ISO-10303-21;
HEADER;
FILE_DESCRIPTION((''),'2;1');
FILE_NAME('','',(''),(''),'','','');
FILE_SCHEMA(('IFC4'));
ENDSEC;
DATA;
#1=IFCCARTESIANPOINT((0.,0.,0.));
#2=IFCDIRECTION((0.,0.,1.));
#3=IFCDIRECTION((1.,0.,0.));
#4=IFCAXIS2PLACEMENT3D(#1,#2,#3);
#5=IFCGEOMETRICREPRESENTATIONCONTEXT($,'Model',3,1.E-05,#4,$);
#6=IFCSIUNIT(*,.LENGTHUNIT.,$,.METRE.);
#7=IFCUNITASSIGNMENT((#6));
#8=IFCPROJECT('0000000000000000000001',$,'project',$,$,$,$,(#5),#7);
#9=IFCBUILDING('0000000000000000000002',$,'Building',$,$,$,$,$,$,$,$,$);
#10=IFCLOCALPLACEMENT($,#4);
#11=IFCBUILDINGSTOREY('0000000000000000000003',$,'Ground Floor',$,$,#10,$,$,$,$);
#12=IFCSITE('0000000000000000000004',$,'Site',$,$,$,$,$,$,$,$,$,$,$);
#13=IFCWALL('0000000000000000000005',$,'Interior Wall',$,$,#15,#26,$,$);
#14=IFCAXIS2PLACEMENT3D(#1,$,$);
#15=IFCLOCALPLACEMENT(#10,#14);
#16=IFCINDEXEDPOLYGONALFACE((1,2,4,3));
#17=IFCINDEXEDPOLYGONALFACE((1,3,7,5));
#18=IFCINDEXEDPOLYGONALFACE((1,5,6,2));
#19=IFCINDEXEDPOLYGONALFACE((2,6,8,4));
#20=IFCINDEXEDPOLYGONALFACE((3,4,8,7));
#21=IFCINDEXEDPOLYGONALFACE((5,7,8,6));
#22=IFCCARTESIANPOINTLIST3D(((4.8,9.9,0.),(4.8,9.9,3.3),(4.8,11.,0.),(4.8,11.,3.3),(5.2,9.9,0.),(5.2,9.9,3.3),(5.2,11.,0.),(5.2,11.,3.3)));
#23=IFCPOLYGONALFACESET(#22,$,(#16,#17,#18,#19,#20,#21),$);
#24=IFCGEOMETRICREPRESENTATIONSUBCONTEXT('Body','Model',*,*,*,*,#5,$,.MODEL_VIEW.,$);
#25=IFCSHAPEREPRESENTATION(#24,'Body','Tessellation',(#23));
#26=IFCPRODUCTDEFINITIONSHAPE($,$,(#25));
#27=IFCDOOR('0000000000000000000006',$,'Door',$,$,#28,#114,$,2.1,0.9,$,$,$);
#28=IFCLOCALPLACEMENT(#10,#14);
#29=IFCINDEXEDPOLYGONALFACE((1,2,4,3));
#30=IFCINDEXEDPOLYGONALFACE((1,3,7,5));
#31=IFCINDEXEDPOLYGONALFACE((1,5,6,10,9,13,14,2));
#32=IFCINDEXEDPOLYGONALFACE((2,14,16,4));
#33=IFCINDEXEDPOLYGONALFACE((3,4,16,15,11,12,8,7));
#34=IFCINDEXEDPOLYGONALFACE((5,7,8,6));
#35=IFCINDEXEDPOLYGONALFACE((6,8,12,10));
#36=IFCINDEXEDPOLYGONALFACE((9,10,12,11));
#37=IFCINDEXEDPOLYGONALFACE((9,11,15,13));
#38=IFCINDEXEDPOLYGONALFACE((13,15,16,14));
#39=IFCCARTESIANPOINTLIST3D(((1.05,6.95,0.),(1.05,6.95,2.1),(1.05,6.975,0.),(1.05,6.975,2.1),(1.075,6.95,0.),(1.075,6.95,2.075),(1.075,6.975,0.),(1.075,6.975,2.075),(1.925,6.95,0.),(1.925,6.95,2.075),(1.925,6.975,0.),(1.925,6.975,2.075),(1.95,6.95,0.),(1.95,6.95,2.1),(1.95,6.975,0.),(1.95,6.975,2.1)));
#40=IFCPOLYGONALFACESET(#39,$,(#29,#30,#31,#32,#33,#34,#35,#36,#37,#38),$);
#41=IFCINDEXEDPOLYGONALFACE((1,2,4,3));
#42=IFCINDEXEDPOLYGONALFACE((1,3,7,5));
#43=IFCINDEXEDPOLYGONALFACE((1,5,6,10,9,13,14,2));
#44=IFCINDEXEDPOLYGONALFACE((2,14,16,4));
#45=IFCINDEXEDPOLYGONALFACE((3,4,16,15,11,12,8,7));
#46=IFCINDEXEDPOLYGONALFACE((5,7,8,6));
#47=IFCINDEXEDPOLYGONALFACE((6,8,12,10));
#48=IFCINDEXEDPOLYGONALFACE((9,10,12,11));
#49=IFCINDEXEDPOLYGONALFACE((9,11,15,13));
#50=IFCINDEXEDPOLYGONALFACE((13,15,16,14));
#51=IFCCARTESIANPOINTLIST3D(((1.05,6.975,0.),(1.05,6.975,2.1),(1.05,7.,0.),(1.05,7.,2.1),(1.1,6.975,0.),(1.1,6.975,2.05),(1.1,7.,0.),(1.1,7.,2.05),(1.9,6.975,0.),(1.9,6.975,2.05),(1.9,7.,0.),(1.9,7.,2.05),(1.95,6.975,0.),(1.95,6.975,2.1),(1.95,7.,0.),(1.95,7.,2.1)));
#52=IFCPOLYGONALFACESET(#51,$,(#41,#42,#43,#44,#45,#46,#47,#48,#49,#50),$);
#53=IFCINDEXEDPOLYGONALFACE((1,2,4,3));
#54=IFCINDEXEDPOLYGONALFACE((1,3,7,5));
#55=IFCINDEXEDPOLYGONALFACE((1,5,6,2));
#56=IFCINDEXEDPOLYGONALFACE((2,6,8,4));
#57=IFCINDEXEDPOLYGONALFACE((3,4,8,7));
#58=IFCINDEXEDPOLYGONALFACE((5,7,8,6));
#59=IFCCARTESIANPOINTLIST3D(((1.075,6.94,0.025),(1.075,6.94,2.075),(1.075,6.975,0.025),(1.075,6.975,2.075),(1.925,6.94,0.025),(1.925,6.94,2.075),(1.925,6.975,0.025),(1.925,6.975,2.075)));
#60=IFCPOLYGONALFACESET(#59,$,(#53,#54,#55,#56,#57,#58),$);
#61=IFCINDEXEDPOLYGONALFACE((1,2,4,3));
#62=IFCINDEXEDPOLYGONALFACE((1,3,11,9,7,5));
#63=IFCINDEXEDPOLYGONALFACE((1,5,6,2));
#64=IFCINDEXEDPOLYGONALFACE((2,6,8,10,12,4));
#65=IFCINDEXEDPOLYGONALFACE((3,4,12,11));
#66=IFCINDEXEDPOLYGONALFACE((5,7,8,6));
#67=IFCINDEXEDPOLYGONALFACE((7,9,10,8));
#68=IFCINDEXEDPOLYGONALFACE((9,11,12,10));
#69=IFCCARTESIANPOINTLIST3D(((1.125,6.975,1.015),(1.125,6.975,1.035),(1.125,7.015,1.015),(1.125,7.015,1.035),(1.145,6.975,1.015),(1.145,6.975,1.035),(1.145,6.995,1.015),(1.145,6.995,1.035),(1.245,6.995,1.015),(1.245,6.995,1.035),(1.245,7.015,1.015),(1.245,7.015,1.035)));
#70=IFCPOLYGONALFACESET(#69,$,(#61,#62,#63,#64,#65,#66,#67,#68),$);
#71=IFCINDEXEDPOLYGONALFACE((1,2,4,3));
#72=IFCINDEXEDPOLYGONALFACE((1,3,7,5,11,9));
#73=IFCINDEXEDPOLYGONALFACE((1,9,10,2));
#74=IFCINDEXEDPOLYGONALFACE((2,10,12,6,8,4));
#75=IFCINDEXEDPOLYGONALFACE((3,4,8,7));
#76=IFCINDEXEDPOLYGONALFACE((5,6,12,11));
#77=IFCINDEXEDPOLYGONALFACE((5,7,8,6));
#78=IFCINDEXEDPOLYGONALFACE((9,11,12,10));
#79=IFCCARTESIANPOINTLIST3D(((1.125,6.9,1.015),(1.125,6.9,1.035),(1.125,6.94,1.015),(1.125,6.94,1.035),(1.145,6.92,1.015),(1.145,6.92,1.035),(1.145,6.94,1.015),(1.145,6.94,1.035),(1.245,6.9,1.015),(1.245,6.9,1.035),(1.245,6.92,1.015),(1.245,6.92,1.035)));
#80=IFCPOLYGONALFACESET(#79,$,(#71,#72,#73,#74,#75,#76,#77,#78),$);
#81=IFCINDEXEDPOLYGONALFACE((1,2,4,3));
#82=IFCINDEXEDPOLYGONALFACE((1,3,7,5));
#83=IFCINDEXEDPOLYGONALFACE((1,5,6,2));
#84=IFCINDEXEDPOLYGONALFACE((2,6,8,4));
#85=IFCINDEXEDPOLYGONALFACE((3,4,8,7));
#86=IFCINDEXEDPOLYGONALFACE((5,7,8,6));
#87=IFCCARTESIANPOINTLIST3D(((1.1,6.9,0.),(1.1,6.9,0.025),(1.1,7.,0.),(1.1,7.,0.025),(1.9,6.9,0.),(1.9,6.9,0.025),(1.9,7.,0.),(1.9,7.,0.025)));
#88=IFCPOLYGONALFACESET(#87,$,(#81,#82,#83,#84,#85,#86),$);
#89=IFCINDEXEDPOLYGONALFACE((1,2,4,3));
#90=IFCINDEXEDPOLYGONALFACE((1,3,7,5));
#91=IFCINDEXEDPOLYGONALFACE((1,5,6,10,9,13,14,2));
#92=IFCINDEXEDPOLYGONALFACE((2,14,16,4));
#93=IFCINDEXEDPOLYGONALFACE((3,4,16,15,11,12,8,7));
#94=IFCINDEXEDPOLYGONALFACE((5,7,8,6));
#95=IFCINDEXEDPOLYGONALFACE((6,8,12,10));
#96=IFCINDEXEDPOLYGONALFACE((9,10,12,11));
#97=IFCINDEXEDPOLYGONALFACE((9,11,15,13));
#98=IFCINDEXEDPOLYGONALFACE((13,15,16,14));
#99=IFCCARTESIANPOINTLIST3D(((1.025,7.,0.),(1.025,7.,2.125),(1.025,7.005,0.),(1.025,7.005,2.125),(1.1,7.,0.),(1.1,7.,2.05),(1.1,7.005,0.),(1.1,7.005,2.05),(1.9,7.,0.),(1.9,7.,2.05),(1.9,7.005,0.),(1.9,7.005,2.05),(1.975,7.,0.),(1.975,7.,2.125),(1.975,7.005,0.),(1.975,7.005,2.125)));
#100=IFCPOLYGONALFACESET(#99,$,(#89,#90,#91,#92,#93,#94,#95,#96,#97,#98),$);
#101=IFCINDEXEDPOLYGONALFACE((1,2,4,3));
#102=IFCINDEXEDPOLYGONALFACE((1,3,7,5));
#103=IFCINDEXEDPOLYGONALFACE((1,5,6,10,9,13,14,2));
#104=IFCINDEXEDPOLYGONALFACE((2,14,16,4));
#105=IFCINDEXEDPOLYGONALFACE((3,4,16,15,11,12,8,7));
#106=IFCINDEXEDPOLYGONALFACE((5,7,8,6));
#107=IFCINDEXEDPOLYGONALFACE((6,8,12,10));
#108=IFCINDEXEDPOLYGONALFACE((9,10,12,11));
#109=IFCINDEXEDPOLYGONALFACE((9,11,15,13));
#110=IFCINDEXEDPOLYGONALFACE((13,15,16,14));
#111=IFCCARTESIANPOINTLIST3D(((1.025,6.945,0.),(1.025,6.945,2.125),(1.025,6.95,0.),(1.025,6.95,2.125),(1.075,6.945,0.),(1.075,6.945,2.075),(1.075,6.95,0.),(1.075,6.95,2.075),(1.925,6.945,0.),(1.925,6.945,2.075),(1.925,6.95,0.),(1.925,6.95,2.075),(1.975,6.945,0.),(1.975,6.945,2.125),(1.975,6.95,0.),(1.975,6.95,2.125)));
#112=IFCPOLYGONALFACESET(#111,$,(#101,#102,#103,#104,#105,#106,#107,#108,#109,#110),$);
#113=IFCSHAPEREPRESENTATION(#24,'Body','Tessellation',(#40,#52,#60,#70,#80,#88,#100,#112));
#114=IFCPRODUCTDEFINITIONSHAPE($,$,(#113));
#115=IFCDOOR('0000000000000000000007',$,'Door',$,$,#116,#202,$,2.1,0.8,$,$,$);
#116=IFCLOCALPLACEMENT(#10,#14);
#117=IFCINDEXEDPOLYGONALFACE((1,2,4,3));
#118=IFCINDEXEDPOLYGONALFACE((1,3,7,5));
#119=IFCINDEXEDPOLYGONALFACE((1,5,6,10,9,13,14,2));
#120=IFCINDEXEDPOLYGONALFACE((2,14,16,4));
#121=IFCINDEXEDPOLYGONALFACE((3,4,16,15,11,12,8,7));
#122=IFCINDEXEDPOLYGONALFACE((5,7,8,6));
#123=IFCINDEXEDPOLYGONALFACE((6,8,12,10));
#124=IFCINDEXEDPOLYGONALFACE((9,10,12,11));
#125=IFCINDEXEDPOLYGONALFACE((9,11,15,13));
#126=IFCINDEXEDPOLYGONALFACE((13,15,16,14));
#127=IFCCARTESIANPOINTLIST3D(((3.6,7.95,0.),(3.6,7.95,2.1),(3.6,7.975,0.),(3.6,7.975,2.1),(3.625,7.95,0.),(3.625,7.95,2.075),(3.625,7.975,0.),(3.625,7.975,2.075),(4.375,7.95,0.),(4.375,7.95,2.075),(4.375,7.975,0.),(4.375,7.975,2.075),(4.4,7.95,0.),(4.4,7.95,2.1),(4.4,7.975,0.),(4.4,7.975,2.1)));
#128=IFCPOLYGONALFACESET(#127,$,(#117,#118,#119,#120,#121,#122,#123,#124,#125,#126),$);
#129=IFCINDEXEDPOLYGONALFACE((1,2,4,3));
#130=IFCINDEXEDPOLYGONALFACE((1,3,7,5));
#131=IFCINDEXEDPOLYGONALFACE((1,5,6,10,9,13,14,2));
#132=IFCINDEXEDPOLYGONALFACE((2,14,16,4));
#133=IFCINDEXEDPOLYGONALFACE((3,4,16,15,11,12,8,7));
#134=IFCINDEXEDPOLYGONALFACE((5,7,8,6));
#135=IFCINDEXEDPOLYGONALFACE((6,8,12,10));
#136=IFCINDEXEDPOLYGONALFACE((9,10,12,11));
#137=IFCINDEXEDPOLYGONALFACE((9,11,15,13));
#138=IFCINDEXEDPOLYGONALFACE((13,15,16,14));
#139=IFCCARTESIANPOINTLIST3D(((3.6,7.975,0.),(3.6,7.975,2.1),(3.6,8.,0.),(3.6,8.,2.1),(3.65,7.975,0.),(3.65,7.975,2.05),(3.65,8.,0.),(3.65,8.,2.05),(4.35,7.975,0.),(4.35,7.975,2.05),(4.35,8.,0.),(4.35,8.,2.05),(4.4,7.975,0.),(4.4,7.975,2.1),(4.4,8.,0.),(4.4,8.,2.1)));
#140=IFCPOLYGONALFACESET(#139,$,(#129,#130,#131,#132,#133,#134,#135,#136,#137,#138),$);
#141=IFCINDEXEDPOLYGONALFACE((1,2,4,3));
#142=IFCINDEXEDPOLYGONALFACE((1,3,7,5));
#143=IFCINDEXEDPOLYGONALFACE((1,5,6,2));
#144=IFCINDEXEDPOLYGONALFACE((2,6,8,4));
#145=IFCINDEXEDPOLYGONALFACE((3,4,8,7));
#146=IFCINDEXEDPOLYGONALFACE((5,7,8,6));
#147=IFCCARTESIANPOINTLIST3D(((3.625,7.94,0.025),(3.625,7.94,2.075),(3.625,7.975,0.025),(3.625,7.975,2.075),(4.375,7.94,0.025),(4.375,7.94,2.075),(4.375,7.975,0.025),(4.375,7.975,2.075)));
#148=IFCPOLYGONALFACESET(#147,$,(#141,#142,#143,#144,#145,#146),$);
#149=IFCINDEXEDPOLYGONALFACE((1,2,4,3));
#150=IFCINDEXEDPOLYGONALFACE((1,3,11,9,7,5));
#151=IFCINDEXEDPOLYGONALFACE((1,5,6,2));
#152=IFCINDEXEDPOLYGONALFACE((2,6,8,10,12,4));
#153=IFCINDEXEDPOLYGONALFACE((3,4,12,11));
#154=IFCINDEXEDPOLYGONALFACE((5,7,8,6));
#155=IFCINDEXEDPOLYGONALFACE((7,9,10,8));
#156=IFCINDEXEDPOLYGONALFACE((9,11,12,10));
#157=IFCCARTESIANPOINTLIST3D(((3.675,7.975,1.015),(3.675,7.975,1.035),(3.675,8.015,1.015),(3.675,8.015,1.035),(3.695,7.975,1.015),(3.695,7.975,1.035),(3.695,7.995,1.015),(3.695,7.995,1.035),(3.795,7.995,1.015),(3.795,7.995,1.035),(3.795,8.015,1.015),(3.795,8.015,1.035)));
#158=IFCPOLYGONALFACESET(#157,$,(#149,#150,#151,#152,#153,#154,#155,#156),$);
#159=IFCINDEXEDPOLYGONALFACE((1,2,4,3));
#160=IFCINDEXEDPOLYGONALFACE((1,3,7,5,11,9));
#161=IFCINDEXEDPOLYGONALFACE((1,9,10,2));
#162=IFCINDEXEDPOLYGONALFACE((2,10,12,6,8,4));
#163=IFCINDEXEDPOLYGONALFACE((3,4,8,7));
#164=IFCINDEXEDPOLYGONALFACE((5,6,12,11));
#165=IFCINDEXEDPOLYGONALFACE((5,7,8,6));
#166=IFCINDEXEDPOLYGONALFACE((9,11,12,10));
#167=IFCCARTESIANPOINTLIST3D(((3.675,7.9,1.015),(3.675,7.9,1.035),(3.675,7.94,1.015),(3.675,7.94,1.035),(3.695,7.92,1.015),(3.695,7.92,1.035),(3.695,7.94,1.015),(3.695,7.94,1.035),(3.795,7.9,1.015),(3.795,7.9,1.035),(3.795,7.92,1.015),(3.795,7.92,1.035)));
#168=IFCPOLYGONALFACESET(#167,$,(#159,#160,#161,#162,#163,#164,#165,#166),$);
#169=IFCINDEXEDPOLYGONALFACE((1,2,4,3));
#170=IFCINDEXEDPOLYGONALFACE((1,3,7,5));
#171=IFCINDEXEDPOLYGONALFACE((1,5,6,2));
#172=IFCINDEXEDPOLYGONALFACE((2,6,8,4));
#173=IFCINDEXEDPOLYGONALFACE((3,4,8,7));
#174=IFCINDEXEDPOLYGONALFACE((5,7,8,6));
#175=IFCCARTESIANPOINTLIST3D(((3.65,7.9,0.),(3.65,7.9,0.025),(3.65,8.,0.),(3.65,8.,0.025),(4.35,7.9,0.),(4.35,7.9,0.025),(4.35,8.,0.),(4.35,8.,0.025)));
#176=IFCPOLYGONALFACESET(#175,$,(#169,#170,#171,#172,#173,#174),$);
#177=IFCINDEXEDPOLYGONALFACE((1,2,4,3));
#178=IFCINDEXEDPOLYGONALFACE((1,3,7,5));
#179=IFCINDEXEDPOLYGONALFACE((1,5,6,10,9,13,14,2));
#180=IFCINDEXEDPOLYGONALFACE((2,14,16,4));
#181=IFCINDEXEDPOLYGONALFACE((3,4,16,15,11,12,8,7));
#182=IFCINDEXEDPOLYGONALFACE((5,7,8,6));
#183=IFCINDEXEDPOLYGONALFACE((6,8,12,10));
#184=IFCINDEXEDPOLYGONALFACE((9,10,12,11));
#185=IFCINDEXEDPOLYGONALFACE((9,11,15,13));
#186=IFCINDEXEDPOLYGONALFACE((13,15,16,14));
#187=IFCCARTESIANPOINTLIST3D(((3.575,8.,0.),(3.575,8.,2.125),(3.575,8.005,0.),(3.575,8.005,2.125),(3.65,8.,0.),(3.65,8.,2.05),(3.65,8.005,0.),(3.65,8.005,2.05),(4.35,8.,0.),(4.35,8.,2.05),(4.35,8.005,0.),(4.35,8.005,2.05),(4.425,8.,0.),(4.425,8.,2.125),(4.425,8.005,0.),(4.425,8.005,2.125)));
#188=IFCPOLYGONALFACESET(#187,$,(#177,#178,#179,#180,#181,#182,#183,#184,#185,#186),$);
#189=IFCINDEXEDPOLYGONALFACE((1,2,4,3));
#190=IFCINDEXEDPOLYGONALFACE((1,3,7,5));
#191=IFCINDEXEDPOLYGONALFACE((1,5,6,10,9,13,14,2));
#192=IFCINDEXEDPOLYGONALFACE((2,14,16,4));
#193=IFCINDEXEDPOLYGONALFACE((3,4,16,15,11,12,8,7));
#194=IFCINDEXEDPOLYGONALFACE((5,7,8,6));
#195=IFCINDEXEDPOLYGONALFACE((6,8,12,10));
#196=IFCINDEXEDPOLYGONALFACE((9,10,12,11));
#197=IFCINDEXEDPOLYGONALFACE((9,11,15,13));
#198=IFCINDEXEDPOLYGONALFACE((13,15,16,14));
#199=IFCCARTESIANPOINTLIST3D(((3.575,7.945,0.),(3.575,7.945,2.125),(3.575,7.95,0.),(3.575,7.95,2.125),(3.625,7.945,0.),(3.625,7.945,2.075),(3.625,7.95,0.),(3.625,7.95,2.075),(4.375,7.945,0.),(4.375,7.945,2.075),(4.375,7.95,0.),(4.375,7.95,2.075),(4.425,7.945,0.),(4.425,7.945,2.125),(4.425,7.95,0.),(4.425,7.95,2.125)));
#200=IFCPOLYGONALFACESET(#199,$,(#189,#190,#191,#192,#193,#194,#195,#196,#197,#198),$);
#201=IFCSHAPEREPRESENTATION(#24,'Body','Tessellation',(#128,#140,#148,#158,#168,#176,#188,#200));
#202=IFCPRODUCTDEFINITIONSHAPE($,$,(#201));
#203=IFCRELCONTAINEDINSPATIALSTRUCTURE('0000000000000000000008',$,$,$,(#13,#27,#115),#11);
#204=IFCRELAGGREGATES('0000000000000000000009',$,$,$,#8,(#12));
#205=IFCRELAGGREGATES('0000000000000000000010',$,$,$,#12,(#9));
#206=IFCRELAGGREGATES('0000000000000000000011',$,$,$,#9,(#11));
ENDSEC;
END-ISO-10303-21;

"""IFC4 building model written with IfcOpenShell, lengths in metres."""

from ifc_helpers import new_model, si_unit, frame, origin_with_axes, place, context, subcontext, project, spatial, line, indexed_curve, outline, extrude, element, save


model = new_model("IFC4")

# Units and contexts
model_context = context("Model", 3, precision=1e-05, world=origin_with_axes())
body_context = subcontext(model_context, "Body", "Model", "MODEL_VIEW")
ifc_project = project(units=[si_unit("LENGTHUNIT", "METRE")], contexts=[model_context])

# Site, building, storey
site = spatial("IfcSite", under=ifc_project, Name="Site")
building = spatial("IfcBuilding", under=site, Name="Building")
storey_placement = place(None, origin_with_axes())
storey = spatial("IfcBuildingStorey", under=building, at=storey_placement, Name="Ground Floor")

# Wall
for number, where, z_axis, x_axis, name in (
    (1, (5.0, 9.9, 0.0), (0.0, 0.0, 1.0), (0.0, 1.0, 0.0), "Interior Wall"),
):
    element("IfcWall", number, at=place(storey_placement, frame(where, z_axis=z_axis, x_axis=x_axis)), inside=storey, Name=name, context=body_context, shape_type="SweptSolid", body=[
        extrude(outline(indexed_curve([(0.0, 0.0), (0.0, 0.4), (1.1, 0.4), (1.1, 0.0), (0.0, 0.0)], self_intersect=False)), frame((0.0, -0.2, 0.0), z_axis=(0.0, 0.0, 1.0), x_axis=(1.0, 0.0, 0.0)), (0.0, 0.0, 1.0), 3.3),
    ])

# Doors
door_1_placement = place(storey_placement, frame((1.95, 7.0, 0.0), z_axis=(0.0, 0.0, 1.0), x_axis=(-1.0, 0.0, 0.0)))
element("IfcDoor", 2, at=door_1_placement, inside=storey, Name="Door", OverallHeight=2.1, OverallWidth=0.9, context=body_context, shape_type="SweptSolid", body=[
    extrude(outline(indexed_curve([(0.0, 0.0), (0.0, 2.1), (0.9, 2.1), (0.9, 0.0), (0.875, 0.0), (0.875, 2.075), (0.025, 2.075), (0.025, 0.0)], segments=[line(1, 2, 3, 4, 5, 6, 7, 8, 1)])), frame((0.0, 0.025, 0.0), z_axis=(0.0, -1.0, 0.0), x_axis=(1.0, 0.0, 0.0)), (0.0, 0.0, -1.0), 0.025),
    extrude(outline(indexed_curve([(0.0, 0.0), (0.0, 2.1), (0.9, 2.1), (0.9, 0.0), (0.85, 0.0), (0.85, 2.05), (0.05, 2.05), (0.05, 0.0)], segments=[line(1, 2, 3, 4, 5, 6, 7, 8, 1)])), frame((0.0, 0.0, 0.0), z_axis=(0.0, -1.0, 0.0), x_axis=(1.0, 0.0, 0.0)), (0.0, 0.0, -1.0), 0.025),
    extrude(outline(indexed_curve([(0.0, 0.0), (0.85, 0.0), (0.85, 0.035), (0.0, 0.035)], segments=[line(1, 2, 3, 4, 1)])), frame((0.025, 0.025, 0.025), z_axis=(0.0, 0.0, 1.0), x_axis=(1.0, 0.0, 0.0)), (0.0, 0.0, 1.0), 2.05),
    extrude(outline(indexed_curve([(0.0, 0.0), (0.0, -0.04), (-0.12, -0.04), (-0.12, -0.02), (-0.02, -0.02), (-0.02, 0.0)], segments=[line(1, 2, 3, 4, 5, 6, 1)])), frame((0.825, 0.025, 1.015), z_axis=(0.0, 0.0, 1.0), x_axis=(1.0, 0.0, 0.0)), (0.0, 0.0, 1.0), 0.02),
    extrude(outline(indexed_curve([(0.0, 0.0), (0.0, 0.04), (-0.12, 0.04), (-0.12, 0.02), (-0.02, 0.02), (-0.02, 0.0)], segments=[line(1, 2, 3, 4, 5, 6, 1)])), frame((0.825, 0.06, 1.015), z_axis=(0.0, 0.0, 1.0), x_axis=(1.0, 0.0, 0.0)), (0.0, 0.0, 1.0), 0.02),
    extrude(outline(indexed_curve([(0.0, 0.0), (0.8, 0.0), (0.8, 0.1), (0.0, 0.1)], segments=[line(1, 2, 3, 4, 1)])), frame((0.05, 0.0, 0.0), z_axis=(0.0, 0.0, 1.0), x_axis=(1.0, 0.0, 0.0)), (0.0, 0.0, 1.0), 0.025),
    extrude(outline(indexed_curve([(0.0, 0.0), (0.0, 2.125), (0.95, 2.125), (0.95, 0.0), (0.875, 0.0), (0.875, 2.05), (0.075, 2.05), (0.075, 0.0)], segments=[line(1, 2, 3, 4, 5, 6, 7, 8, 1)])), frame((-0.025, -0.005, 0.0), z_axis=(0.0, -1.0, 0.0), x_axis=(1.0, 0.0, 0.0)), (0.0, 0.0, -1.0), 0.005),
    extrude(outline(indexed_curve([(0.0, 0.0), (0.0, 2.125), (0.95, 2.125), (0.95, 0.0), (0.9, 0.0), (0.9, 2.075), (0.05, 2.075), (0.05, 0.0)], segments=[line(1, 2, 3, 4, 5, 6, 7, 8, 1)])), frame((-0.025, 0.05, 0.0), z_axis=(0.0, -1.0, 0.0), x_axis=(1.0, 0.0, 0.0)), (0.0, 0.0, -1.0), 0.005),
])
door_2_placement = place(storey_placement, frame((4.4, 8.0, 0.0), z_axis=(0.0, 0.0, 1.0), x_axis=(-1.0, 0.0, 0.0)))
element("IfcDoor", 3, at=door_2_placement, inside=storey, Name="Door", OverallHeight=2.1, OverallWidth=0.8, context=body_context, shape_type="SweptSolid", body=[
    extrude(outline(indexed_curve([(0.0, 0.0), (0.0, 2.1), (0.8, 2.1), (0.8, 0.0), (0.775, 0.0), (0.775, 2.075), (0.025, 2.075), (0.025, 0.0)], segments=[line(1, 2, 3, 4, 5, 6, 7, 8, 1)])), frame((0.0, 0.025, 0.0), z_axis=(0.0, -1.0, 0.0), x_axis=(1.0, 0.0, 0.0)), (0.0, 0.0, -1.0), 0.025),
    extrude(outline(indexed_curve([(0.0, 0.0), (0.0, 2.1), (0.8, 2.1), (0.8, 0.0), (0.75, 0.0), (0.75, 2.05), (0.05, 2.05), (0.05, 0.0)], segments=[line(1, 2, 3, 4, 5, 6, 7, 8, 1)])), frame((0.0, 0.0, 0.0), z_axis=(0.0, -1.0, 0.0), x_axis=(1.0, 0.0, 0.0)), (0.0, 0.0, -1.0), 0.025),
    extrude(outline(indexed_curve([(0.0, 0.0), (0.75, 0.0), (0.75, 0.035), (0.0, 0.035)], segments=[line(1, 2, 3, 4, 1)])), frame((0.025, 0.025, 0.025), z_axis=(0.0, 0.0, 1.0), x_axis=(1.0, 0.0, 0.0)), (0.0, 0.0, 1.0), 2.05),
    extrude(outline(indexed_curve([(0.0, 0.0), (0.0, -0.04), (-0.12, -0.04), (-0.12, -0.02), (-0.02, -0.02), (-0.02, 0.0)], segments=[line(1, 2, 3, 4, 5, 6, 1)])), frame((0.725, 0.025, 1.015), z_axis=(0.0, 0.0, 1.0), x_axis=(1.0, 0.0, 0.0)), (0.0, 0.0, 1.0), 0.02),
    extrude(outline(indexed_curve([(0.0, 0.0), (0.0, 0.04), (-0.12, 0.04), (-0.12, 0.02), (-0.02, 0.02), (-0.02, 0.0)], segments=[line(1, 2, 3, 4, 5, 6, 1)])), frame((0.725, 0.06, 1.015), z_axis=(0.0, 0.0, 1.0), x_axis=(1.0, 0.0, 0.0)), (0.0, 0.0, 1.0), 0.02),
    extrude(outline(indexed_curve([(0.0, 0.0), (0.7, 0.0), (0.7, 0.1), (0.0, 0.1)], segments=[line(1, 2, 3, 4, 1)])), frame((0.05, 0.0, 0.0), z_axis=(0.0, 0.0, 1.0), x_axis=(1.0, 0.0, 0.0)), (0.0, 0.0, 1.0), 0.025),
    extrude(outline(indexed_curve([(0.0, 0.0), (0.0, 2.125), (0.85, 2.125), (0.85, 0.0), (0.775, 0.0), (0.775, 2.05), (0.075, 2.05), (0.075, 0.0)], segments=[line(1, 2, 3, 4, 5, 6, 7, 8, 1)])), frame((-0.025, -0.005, 0.0), z_axis=(0.0, -1.0, 0.0), x_axis=(1.0, 0.0, 0.0)), (0.0, 0.0, -1.0), 0.005),
    extrude(outline(indexed_curve([(0.0, 0.0), (0.0, 2.125), (0.85, 2.125), (0.85, 0.0), (0.8, 0.0), (0.8, 2.075), (0.05, 2.075), (0.05, 0.0)], segments=[line(1, 2, 3, 4, 5, 6, 7, 8, 1)])), frame((-0.025, 0.05, 0.0), z_axis=(0.0, -1.0, 0.0), x_axis=(1.0, 0.0, 0.0)), (0.0, 0.0, -1.0), 0.005),
])

save(model, "model.ifc")
